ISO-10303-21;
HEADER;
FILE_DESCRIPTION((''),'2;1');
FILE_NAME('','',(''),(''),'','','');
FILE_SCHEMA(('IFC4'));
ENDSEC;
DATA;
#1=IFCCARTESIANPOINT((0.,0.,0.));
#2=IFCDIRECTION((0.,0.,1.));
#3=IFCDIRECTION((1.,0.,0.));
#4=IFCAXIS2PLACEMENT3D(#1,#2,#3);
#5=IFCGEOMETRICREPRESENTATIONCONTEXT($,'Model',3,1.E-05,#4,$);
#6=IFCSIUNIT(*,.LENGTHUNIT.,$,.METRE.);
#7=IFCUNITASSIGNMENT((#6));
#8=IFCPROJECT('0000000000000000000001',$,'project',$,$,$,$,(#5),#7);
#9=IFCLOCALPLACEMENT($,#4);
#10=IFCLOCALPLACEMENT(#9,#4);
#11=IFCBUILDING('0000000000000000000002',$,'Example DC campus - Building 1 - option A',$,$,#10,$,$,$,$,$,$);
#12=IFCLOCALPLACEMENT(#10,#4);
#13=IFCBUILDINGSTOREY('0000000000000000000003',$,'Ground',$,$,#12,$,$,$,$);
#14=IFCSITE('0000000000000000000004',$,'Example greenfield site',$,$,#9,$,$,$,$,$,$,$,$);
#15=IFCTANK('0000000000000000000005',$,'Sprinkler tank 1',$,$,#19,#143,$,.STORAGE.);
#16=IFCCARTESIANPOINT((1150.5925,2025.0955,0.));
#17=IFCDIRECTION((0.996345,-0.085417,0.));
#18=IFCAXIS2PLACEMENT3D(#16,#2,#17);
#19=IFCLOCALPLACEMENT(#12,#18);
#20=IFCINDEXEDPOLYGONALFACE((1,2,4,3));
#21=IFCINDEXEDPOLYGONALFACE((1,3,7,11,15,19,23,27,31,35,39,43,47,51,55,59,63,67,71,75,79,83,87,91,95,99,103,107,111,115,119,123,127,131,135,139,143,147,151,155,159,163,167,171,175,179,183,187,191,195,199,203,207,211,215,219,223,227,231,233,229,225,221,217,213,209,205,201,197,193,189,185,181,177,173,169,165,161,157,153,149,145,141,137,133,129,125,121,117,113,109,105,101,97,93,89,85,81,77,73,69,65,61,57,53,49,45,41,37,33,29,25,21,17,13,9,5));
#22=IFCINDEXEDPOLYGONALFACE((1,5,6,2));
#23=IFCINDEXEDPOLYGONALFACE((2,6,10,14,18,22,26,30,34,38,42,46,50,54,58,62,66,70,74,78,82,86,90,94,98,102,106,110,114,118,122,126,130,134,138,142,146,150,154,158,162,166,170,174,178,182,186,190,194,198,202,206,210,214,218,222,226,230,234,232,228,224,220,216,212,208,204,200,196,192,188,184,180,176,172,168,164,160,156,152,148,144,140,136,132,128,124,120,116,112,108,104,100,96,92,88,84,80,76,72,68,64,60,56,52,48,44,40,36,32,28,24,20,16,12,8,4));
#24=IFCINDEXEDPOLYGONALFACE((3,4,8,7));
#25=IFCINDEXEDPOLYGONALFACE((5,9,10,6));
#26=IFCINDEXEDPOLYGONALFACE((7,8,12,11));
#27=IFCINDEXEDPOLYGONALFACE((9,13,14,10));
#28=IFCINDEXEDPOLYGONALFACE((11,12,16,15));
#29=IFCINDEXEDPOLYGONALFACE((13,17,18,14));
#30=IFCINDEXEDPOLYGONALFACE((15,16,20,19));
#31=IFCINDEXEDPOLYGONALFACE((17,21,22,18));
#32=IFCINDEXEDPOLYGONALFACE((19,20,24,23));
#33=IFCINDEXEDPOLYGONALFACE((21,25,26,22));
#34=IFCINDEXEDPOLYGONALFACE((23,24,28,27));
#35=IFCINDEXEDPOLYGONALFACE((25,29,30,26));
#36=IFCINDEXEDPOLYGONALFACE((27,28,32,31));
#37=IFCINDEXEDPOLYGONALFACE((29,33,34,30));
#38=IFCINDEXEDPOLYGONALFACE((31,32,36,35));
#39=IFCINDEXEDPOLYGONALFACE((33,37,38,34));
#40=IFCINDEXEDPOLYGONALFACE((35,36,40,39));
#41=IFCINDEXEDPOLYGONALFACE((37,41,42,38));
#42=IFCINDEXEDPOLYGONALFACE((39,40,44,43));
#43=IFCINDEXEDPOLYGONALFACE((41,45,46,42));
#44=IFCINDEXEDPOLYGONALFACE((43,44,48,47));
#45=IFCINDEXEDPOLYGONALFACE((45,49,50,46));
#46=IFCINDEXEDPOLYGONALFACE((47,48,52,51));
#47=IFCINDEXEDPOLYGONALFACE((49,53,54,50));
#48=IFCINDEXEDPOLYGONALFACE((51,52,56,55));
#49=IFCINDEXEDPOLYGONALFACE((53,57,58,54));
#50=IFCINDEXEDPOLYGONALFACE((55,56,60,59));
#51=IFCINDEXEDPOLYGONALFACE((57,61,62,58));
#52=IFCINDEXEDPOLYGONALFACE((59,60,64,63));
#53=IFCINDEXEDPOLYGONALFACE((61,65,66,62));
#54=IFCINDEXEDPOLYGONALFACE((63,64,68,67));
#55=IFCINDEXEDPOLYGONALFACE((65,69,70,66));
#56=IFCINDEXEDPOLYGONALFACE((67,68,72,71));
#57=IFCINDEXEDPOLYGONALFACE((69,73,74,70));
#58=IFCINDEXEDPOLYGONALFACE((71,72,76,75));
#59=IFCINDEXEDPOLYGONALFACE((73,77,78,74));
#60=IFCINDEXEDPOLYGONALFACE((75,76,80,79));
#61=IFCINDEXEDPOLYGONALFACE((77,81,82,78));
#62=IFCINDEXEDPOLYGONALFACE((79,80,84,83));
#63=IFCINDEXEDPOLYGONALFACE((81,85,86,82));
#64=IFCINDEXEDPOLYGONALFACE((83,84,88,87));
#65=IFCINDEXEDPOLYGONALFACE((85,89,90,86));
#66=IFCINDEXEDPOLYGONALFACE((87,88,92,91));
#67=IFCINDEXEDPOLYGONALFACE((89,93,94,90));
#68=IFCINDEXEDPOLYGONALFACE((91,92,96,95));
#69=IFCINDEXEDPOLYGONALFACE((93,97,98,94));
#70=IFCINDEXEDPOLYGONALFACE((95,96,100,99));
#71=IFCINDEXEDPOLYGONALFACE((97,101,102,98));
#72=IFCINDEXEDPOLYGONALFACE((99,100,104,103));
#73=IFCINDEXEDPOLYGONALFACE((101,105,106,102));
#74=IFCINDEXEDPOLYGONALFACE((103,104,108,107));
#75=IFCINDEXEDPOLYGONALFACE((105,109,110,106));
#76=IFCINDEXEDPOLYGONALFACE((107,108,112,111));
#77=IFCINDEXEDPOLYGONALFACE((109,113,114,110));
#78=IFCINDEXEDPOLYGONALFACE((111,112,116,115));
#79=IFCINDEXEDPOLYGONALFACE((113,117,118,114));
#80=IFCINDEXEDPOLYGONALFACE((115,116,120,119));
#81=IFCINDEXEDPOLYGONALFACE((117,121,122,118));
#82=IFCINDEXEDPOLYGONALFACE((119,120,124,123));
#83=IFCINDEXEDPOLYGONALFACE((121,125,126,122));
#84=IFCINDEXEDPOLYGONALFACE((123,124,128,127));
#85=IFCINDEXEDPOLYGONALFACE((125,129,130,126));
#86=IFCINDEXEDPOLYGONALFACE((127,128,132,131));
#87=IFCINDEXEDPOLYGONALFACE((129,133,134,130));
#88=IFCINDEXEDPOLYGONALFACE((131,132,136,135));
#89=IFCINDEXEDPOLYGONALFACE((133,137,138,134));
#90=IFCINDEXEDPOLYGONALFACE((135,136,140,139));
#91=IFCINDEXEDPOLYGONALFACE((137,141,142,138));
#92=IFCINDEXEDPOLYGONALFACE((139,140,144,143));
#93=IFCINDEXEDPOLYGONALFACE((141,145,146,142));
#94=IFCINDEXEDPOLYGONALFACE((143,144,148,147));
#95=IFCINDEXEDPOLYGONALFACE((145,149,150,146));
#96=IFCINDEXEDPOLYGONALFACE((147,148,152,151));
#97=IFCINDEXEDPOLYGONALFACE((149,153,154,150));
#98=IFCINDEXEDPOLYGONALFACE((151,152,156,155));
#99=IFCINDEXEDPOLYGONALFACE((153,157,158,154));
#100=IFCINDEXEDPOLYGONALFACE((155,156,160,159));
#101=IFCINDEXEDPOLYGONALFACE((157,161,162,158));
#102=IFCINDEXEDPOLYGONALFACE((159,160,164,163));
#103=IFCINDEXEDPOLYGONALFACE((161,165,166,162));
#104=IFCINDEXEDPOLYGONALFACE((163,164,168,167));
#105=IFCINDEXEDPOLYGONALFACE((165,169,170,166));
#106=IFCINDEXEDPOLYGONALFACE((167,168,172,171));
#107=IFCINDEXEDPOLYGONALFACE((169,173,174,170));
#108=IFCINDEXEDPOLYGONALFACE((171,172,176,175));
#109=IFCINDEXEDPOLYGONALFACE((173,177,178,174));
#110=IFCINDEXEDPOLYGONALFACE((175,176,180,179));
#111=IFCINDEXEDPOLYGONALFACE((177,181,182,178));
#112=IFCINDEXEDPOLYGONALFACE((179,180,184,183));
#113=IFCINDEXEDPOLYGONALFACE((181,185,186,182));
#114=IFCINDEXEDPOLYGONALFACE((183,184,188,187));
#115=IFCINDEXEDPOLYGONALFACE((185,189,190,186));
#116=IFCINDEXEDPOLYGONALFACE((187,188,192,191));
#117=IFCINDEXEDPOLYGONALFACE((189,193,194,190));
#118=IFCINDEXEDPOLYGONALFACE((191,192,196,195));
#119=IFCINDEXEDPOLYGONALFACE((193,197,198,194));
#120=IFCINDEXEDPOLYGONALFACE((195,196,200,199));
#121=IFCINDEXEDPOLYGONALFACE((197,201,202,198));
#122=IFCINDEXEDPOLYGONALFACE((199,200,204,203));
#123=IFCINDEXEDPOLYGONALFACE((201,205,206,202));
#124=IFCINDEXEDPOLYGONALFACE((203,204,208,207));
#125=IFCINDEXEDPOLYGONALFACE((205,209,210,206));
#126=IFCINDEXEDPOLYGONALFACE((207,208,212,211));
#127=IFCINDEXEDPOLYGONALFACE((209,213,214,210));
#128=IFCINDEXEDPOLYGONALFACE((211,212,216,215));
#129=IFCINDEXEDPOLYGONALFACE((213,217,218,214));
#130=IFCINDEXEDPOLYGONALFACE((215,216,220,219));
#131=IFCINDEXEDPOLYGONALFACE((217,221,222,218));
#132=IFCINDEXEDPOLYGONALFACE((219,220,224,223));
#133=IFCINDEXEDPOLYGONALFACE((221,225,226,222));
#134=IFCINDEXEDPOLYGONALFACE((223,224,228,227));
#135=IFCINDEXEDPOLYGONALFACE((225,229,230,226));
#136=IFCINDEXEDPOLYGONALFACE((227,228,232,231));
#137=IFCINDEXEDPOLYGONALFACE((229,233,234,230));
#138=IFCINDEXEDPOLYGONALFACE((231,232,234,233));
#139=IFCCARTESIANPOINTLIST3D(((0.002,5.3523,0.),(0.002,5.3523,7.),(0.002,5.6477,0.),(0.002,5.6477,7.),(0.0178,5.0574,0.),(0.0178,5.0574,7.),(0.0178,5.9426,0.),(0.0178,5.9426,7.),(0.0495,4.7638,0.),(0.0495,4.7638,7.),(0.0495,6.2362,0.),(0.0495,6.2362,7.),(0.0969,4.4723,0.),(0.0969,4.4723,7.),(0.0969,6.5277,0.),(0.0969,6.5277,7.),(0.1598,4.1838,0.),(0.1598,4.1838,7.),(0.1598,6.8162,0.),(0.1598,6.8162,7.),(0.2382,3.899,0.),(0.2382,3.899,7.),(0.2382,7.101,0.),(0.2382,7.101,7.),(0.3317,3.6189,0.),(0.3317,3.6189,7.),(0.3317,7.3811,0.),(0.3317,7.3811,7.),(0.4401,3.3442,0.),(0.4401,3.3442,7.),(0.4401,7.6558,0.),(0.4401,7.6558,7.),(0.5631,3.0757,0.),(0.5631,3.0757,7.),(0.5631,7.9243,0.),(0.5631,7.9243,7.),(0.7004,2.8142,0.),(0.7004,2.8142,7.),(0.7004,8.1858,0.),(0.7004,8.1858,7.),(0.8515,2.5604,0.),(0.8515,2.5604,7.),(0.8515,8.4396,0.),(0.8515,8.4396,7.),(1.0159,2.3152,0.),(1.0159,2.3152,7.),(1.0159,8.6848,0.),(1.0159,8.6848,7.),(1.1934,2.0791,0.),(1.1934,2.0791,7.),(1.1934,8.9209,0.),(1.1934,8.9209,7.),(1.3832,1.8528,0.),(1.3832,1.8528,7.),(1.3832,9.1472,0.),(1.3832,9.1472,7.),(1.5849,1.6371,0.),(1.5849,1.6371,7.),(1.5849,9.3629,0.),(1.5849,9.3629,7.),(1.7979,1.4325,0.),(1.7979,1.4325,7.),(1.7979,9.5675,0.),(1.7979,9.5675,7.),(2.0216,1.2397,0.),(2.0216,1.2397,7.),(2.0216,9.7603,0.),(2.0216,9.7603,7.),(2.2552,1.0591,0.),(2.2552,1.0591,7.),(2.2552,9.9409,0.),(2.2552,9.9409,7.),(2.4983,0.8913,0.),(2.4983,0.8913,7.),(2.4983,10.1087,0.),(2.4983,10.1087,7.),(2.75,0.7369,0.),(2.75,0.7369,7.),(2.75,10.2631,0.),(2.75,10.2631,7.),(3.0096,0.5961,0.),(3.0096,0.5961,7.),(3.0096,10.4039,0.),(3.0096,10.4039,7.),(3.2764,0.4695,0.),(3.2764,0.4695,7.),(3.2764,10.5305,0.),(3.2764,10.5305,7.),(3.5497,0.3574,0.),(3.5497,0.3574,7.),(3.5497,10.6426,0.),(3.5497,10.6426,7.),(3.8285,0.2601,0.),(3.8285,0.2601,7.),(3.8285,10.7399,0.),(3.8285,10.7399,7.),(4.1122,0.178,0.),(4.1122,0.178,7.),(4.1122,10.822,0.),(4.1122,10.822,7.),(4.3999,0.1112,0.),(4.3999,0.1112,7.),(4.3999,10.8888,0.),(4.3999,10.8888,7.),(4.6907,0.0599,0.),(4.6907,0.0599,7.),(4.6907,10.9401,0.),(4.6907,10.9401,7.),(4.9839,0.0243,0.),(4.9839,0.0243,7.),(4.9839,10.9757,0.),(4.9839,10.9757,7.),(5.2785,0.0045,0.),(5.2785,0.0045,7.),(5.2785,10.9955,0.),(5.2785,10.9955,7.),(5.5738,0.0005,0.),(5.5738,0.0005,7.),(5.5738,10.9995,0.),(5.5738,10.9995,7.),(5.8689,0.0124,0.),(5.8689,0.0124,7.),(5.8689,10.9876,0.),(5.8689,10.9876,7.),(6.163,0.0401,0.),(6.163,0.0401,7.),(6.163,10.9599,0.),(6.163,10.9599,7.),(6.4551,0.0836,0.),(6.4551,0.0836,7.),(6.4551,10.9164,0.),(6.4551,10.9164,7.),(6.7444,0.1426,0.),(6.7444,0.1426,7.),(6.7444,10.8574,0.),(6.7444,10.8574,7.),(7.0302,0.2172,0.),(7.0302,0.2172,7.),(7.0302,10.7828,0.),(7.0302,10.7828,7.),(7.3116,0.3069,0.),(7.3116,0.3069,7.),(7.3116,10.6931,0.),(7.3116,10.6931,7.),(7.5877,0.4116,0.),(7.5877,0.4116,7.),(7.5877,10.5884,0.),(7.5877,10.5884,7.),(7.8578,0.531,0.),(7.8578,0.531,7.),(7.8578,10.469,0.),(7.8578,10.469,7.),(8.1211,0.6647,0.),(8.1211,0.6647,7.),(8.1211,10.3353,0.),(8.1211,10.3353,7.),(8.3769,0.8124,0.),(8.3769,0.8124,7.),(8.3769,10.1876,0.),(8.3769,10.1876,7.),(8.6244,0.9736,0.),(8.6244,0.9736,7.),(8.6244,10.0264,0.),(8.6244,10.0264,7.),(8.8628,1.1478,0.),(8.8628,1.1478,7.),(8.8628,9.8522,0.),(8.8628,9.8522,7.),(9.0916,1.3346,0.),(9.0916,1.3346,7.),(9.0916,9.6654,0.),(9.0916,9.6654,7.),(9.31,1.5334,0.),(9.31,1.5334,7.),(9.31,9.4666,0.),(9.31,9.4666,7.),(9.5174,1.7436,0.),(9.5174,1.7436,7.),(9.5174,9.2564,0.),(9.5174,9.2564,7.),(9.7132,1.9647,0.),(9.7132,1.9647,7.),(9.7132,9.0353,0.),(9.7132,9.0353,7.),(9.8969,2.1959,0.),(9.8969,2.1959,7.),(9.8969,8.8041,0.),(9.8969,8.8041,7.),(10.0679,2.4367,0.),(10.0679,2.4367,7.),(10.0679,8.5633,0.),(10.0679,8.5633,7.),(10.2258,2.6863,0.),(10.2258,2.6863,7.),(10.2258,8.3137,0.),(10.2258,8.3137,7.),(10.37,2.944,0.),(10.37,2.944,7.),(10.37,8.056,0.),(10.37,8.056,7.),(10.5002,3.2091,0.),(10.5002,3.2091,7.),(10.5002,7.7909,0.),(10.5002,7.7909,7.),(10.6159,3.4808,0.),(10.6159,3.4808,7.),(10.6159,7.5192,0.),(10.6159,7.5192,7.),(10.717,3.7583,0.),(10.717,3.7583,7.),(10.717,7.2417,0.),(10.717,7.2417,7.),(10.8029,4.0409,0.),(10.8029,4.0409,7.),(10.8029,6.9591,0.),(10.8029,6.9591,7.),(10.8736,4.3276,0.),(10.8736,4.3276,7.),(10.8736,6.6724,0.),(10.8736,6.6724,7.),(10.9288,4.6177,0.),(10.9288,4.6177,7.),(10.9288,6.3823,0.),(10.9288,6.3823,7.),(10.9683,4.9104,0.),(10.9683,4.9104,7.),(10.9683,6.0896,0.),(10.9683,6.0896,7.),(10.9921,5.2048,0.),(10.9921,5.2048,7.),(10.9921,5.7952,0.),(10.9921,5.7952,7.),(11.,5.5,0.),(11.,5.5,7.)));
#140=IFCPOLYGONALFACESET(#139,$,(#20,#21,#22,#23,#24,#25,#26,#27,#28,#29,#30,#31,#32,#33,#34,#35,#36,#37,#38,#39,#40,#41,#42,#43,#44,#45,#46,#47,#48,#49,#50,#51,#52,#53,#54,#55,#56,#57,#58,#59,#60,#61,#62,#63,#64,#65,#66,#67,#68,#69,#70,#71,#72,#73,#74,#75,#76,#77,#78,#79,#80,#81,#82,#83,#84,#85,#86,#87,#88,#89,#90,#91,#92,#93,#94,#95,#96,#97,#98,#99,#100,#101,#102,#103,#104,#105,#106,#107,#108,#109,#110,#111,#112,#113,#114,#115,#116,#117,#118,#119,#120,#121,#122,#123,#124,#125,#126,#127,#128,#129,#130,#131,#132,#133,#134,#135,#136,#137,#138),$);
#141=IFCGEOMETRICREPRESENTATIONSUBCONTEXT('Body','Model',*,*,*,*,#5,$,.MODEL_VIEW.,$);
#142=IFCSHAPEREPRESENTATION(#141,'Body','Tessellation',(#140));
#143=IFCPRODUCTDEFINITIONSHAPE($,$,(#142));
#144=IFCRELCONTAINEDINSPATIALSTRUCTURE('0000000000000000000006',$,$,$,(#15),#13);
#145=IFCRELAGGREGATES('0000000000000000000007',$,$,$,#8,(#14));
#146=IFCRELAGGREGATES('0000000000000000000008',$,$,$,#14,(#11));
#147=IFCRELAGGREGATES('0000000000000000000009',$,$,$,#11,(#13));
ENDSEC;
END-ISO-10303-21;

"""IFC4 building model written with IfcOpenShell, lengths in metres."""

from ifc_helpers import new_model, si_unit, frame, frame_2d, origin_with_axes, place, context, subcontext, project, spatial, circle_curve, outline, extrude, element, save


model = new_model("IFC4")

# Units and contexts
model_context = context("Model", 3, precision=1e-05, world=origin_with_axes())
body_context = subcontext(model_context, "Body", "Model", "MODEL_VIEW")
ifc_project = project(units=[si_unit("LENGTHUNIT", "METRE")], contexts=[model_context])

# Site, building, storey
site_placement = place(None, origin_with_axes())
site = spatial("IfcSite", under=ifc_project, at=site_placement, Name="Example greenfield site")
building_placement = place(site_placement, origin_with_axes())
building = spatial("IfcBuilding", under=site, at=building_placement, Name="Example DC campus - Building 1 - option A")
storey_placement = place(building_placement, origin_with_axes())
storey = spatial("IfcBuildingStorey", under=building, at=storey_placement, Name="Ground")

# Tank
for number, where, z_axis, x_axis, name in (
    (1, (1150.5925, 2025.0955, 0.0), (0.0, 0.0, 1.0), (0.996345, -0.085417, 0.0), "Sprinkler tank 1"),
):
    element("IfcTank", number, at=place(storey_placement, frame(where, z_axis=z_axis, x_axis=x_axis)), inside=storey, Name=name, PredefinedType="STORAGE", context=body_context, shape_type="SweptSolid", body=[
        extrude(outline(circle_curve(frame_2d((5.5, 5.5)), 5.5)), origin_with_axes(), (0.0, 0.0, 1.0), 7.0),
    ])

save(model, "model.ifc")
